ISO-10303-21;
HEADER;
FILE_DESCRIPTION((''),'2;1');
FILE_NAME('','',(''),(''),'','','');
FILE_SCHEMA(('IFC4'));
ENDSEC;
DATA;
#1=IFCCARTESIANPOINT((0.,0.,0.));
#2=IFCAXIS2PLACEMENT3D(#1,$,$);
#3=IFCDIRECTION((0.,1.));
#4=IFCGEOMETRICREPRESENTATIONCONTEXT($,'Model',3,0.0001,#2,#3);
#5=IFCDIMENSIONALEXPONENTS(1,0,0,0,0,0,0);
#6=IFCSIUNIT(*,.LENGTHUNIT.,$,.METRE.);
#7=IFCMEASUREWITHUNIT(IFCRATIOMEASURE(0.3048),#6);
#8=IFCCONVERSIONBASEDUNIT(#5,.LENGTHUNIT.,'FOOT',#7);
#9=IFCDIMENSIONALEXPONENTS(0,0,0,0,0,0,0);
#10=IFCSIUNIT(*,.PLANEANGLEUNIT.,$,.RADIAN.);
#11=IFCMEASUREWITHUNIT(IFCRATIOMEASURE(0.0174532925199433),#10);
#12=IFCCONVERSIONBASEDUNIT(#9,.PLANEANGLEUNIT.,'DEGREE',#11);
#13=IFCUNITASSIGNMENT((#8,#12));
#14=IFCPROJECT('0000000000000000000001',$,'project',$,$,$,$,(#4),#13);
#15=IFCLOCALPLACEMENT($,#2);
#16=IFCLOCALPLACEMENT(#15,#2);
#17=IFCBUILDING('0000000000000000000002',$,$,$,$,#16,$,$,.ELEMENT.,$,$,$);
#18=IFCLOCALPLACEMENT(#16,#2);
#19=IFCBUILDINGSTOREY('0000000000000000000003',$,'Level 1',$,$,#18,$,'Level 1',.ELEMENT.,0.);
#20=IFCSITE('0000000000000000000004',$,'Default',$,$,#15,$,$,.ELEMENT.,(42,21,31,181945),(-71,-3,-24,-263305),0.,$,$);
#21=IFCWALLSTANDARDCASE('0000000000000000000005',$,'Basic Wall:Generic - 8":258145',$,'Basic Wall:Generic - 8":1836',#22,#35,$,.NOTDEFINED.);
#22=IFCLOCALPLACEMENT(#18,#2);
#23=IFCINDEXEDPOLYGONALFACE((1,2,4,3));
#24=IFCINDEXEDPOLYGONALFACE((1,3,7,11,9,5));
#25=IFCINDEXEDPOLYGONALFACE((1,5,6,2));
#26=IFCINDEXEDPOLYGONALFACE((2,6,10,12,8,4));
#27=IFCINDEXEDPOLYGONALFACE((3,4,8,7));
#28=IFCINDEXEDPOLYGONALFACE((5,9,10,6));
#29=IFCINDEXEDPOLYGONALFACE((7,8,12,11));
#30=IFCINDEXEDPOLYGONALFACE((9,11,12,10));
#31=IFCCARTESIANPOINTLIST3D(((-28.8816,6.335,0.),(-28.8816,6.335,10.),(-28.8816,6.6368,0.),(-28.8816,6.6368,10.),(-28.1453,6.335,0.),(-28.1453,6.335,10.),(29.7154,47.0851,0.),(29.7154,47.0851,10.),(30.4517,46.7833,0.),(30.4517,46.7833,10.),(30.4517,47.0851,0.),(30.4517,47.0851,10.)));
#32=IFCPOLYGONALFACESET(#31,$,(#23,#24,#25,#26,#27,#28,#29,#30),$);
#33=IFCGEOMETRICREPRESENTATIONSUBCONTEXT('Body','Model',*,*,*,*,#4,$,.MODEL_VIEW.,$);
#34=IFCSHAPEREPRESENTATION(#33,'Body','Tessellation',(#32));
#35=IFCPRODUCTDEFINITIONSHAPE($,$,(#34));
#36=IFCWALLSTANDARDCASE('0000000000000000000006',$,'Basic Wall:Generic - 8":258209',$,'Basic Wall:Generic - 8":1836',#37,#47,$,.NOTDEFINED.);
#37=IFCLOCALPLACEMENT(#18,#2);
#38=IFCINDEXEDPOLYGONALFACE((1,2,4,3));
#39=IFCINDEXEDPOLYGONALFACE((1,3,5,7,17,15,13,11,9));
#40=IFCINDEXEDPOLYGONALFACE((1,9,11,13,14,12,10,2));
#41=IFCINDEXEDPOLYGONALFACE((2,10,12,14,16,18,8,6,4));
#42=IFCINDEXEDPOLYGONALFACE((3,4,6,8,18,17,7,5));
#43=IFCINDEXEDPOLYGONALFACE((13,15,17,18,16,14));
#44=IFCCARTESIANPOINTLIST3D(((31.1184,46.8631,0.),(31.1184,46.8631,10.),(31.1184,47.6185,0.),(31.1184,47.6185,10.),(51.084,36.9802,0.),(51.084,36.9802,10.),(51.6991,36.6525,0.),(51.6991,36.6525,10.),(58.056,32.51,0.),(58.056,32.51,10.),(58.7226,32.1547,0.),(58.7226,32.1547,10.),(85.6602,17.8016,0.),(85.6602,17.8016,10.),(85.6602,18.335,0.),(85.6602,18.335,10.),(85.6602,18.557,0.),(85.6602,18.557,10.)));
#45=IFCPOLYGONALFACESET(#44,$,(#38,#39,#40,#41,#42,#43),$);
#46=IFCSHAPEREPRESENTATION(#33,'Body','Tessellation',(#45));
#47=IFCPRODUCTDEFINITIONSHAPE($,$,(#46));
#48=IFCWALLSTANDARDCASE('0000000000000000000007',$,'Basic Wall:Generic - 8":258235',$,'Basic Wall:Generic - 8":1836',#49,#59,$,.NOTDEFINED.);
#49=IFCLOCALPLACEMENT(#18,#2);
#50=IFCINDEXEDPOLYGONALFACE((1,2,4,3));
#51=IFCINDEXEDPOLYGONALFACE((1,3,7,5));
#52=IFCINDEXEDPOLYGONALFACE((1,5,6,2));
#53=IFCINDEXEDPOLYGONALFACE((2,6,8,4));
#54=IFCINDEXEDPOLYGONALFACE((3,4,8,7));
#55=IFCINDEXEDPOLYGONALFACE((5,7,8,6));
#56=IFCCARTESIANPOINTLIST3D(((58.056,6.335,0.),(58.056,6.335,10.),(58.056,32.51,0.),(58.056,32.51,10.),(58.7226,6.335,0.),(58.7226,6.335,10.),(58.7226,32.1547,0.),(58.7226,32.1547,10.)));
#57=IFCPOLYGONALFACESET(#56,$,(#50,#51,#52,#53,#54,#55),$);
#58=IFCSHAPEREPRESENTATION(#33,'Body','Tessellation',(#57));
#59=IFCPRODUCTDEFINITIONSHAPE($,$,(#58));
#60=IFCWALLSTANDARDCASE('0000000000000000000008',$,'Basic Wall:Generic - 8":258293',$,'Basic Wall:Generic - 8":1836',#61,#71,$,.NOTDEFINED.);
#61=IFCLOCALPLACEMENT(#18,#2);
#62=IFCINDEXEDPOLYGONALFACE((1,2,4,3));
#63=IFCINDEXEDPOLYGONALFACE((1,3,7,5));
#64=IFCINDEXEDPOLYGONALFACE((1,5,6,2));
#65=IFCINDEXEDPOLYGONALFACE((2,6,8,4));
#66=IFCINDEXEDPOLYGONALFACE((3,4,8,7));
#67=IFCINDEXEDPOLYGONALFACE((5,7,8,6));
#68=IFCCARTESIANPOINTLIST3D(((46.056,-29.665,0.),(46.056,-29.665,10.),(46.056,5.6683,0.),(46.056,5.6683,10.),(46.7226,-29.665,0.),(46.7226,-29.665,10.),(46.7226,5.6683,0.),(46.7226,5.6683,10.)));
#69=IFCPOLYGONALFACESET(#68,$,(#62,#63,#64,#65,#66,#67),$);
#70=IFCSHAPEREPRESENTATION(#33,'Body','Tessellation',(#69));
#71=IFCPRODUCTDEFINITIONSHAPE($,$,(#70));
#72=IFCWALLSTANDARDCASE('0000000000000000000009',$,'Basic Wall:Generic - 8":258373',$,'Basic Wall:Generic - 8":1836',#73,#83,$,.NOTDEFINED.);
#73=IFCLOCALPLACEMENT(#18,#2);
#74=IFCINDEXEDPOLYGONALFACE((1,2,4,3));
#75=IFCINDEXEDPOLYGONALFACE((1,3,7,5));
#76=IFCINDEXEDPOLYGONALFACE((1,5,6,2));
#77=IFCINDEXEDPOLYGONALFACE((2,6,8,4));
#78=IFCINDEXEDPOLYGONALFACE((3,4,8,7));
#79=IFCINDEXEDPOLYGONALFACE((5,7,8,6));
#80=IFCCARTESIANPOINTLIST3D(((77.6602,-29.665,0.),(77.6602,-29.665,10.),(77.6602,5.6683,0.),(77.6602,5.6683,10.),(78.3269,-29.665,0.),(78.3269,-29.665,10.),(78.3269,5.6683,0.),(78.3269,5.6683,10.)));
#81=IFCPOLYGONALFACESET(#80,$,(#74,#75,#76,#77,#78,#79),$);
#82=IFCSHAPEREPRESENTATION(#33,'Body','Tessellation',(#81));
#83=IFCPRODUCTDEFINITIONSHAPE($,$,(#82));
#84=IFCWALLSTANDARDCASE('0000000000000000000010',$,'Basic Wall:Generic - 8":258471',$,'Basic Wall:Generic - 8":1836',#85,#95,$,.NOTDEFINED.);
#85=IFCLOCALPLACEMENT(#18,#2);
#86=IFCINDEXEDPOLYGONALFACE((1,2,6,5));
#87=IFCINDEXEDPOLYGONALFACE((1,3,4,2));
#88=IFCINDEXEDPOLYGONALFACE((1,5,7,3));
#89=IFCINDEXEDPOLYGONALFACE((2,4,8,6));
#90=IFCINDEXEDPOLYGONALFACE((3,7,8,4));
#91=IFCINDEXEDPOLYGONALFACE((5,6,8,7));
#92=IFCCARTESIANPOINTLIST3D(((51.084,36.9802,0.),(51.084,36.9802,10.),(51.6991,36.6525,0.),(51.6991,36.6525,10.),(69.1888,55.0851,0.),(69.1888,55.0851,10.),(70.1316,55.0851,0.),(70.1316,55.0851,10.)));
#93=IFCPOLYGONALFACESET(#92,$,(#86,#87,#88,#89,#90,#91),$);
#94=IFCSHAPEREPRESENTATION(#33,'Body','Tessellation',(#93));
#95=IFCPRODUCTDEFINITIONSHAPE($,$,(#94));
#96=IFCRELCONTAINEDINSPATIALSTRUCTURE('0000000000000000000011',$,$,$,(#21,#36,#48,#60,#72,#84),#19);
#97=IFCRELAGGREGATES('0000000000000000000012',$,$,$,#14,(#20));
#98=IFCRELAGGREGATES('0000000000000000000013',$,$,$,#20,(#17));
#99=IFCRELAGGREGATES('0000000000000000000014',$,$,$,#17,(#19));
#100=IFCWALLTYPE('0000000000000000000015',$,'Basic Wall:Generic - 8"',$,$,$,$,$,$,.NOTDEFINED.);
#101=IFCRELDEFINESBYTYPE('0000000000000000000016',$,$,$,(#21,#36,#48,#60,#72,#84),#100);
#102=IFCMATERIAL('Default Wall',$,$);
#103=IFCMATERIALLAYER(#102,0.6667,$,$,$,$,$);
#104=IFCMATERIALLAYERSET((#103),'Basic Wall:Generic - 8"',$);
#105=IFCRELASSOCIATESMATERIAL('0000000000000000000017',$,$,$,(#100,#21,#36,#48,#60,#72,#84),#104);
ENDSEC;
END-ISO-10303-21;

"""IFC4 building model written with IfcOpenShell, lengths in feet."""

from ifc_helpers import new_model, entity, si_unit, converted_unit, direction, frame, frame_2d, origin, place, context, subcontext, project, spatial, polyline, rectangle, outline, extrude, material, layer, layer_set, layer_usage, type_object, element, save


model = new_model("IFC4")

# Units and contexts
model_context = context("Model", 3, precision=0.0001, world=origin(), true_north=direction((0.0, 1.0)))
body_context = subcontext(model_context, "Body", "Model", "MODEL_VIEW")
ifc_project = project(units=[converted_unit("LENGTHUNIT", "FOOT", entity("IfcRatioMeasure", 0.3048), si_unit("LENGTHUNIT", "METRE"), dimensions=[1, 0, 0, 0, 0, 0, 0]), converted_unit("PLANEANGLEUNIT", "DEGREE", entity("IfcRatioMeasure", 0.0174532925199433), si_unit("PLANEANGLEUNIT", "RADIAN"), dimensions=[0, 0, 0, 0, 0, 0, 0])], contexts=[model_context])

# Site, building, storey
site_placement = place(None, origin())
site = spatial("IfcSite", under=ifc_project, at=site_placement, Name="Default", CompositionType="ELEMENT", RefLatitude=(42, 21, 31, 181945), RefLongitude=(-71, -3, -24, -263305), RefElevation=0.0)
building_placement = place(site_placement, origin())
building = spatial("IfcBuilding", under=site, at=building_placement, CompositionType="ELEMENT")
storey_placement = place(building_placement, origin())
storey = spatial("IfcBuildingStorey", under=building, at=storey_placement, Name="Level 1", LongName="Level 1", CompositionType="ELEMENT", Elevation=0.0)

# Shared definitions
ifc_material = material(Name="Default Wall")
ifc_layer = layer(ifc_material, 0.6667)
ifc_layer_set = layer_set([ifc_layer], Name="Basic Wall:Generic - 8\"")
wall_type = type_object("IfcWallType", Name="Basic Wall:Generic - 8\"", PredefinedType="NOTDEFINED", material=ifc_layer_set)

# Walls
ifc_layer_usage_1 = layer_usage(ifc_layer_set, "AXIS2", "NEGATIVE", 0.3333)
wall_1_placement = place(storey_placement, frame((30.2623, 47.0576, 0.0), z_axis=(0.0, 0.0, 1.0), x_axis=(-0.822973, -0.568081, 0.0)))
element("IfcWallStandardCase", 1, at=wall_1_placement, inside=storey, type_object=wall_type, material=ifc_layer_usage_1, Name="Basic Wall:Generic - 8\":258145", ObjectType="Basic Wall:Generic - 8\":1836", PredefinedType="NOTDEFINED", context=body_context, shape_type="SweptSolid", body=[
    extrude(outline(polyline([(71.6362, -0.3333), (71.8076, -0.085), (71.2016, 0.3333), (0.0, 0.3333), (-0.1714, 0.085), (0.4345, -0.3333), (71.6362, -0.3333)])), origin(), (0.0, 0.0, 1.0), 10.0),
])
ifc_layer_usage_2 = layer_usage(ifc_layer_set, "AXIS2", "NEGATIVE", 0.3333)
wall_2_placement = place(storey_placement, frame((30.9616, 47.3243, 0.0), z_axis=(0.0, 0.0, 1.0), x_axis=(0.882538, -0.470242, 0.0)))
element("IfcWallStandardCase", 2, at=wall_2_placement, inside=storey, type_object=wall_type, material=ifc_layer_usage_2, Name="Basic Wall:Generic - 8\":258209", ObjectType="Basic Wall:Generic - 8\":1836", PredefinedType="NOTDEFINED", context=body_context, shape_type="SweptSolid", body=[
    extrude(outline(polyline([(62.1564, -0.3333), (61.9056, 0.1374), (61.8012, 0.3333), (23.3199, 0.3333), (22.623, 0.3333), (0.0, 0.3333), (0.3552, -0.3333), (30.8781, -0.3333), (31.6335, -0.3333), (62.1564, -0.3333)])), origin(), (0.0, 0.0, 1.0), 10.0),
])
ifc_layer_usage_3 = layer_usage(ifc_layer_set, "AXIS2", "NEGATIVE", 0.3333)
wall_3_placement = place(storey_placement, frame((58.3893, 32.51, 0.0), z_axis=(0.0, 0.0, 1.0), x_axis=(0.0, -1.0, 0.0)))
element("IfcWallStandardCase", 3, at=wall_3_placement, inside=storey, type_object=wall_type, material=ifc_layer_usage_3, Name="Basic Wall:Generic - 8\":258235", ObjectType="Basic Wall:Generic - 8\":1836", PredefinedType="NOTDEFINED", context=body_context, shape_type="SweptSolid", body=[
    extrude(outline(polyline([(26.1749, -0.3333), (26.1749, 0.3333), (0.3552, 0.3333), (0.0, -0.3333), (26.1749, -0.3333)])), origin(), (0.0, 0.0, 1.0), 10.0),
])
ifc_layer_usage_4 = layer_usage(ifc_layer_set, "AXIS2", "NEGATIVE", 0.3333)
wall_4_placement = place(storey_placement, frame((46.3893, 5.6683, 0.0), z_axis=(0.0, 0.0, 1.0), x_axis=(0.0, -1.0, 0.0)))
element("IfcWallStandardCase", 4, at=wall_4_placement, inside=storey, type_object=wall_type, material=ifc_layer_usage_4, Name="Basic Wall:Generic - 8\":258293", ObjectType="Basic Wall:Generic - 8\":1836", PredefinedType="NOTDEFINED", context=body_context, shape_type="SweptSolid", body=[
    extrude(rectangle(XDim=35.3333, YDim=0.6667, at=frame_2d((17.6667, 0.0), x_axis=(-1.0, 0.0))), origin(), (0.0, 0.0, 1.0), 10.0),
])
ifc_layer_usage_5 = layer_usage(ifc_layer_set, "AXIS2", "NEGATIVE", 0.3333)
wall_5_placement = place(storey_placement, frame((77.9936, 5.6683, 0.0), z_axis=(0.0, 0.0, 1.0), x_axis=(0.0, -1.0, 0.0)))
element("IfcWallStandardCase", 5, at=wall_5_placement, inside=storey, type_object=wall_type, material=ifc_layer_usage_5, Name="Basic Wall:Generic - 8\":258373", ObjectType="Basic Wall:Generic - 8\":1836", PredefinedType="NOTDEFINED", context=body_context, shape_type="SweptSolid", body=[
    extrude(rectangle(XDim=35.3333, YDim=0.6667, at=frame_2d((17.6667, 0.0), x_axis=(-1.0, 0.0))), origin(), (0.0, 0.0, 1.0), 10.0),
])
ifc_layer_usage_6 = layer_usage(ifc_layer_set, "AXIS2", "NEGATIVE", 0.3333)
wall_6_placement = place(storey_placement, frame((69.8959, 55.3208, 0.0), z_axis=(0.0, 0.0, 1.0), x_axis=(-0.707107, -0.707107, 0.0)))
element("IfcWallStandardCase", 6, at=wall_6_placement, inside=storey, type_object=wall_type, material=ifc_layer_usage_6, Name="Basic Wall:Generic - 8\":258471", ObjectType="Basic Wall:Generic - 8\":1836", PredefinedType="NOTDEFINED", context=body_context, shape_type="SweptSolid", body=[
    extrude(outline(polyline([(26.2708, -0.3333), (26.0676, 0.3333), (0.0, 0.3333), (0.6667, -0.3333), (26.2708, -0.3333)])), origin(), (0.0, 0.0, 1.0), 10.0),
])

save(model, "model.ifc")
